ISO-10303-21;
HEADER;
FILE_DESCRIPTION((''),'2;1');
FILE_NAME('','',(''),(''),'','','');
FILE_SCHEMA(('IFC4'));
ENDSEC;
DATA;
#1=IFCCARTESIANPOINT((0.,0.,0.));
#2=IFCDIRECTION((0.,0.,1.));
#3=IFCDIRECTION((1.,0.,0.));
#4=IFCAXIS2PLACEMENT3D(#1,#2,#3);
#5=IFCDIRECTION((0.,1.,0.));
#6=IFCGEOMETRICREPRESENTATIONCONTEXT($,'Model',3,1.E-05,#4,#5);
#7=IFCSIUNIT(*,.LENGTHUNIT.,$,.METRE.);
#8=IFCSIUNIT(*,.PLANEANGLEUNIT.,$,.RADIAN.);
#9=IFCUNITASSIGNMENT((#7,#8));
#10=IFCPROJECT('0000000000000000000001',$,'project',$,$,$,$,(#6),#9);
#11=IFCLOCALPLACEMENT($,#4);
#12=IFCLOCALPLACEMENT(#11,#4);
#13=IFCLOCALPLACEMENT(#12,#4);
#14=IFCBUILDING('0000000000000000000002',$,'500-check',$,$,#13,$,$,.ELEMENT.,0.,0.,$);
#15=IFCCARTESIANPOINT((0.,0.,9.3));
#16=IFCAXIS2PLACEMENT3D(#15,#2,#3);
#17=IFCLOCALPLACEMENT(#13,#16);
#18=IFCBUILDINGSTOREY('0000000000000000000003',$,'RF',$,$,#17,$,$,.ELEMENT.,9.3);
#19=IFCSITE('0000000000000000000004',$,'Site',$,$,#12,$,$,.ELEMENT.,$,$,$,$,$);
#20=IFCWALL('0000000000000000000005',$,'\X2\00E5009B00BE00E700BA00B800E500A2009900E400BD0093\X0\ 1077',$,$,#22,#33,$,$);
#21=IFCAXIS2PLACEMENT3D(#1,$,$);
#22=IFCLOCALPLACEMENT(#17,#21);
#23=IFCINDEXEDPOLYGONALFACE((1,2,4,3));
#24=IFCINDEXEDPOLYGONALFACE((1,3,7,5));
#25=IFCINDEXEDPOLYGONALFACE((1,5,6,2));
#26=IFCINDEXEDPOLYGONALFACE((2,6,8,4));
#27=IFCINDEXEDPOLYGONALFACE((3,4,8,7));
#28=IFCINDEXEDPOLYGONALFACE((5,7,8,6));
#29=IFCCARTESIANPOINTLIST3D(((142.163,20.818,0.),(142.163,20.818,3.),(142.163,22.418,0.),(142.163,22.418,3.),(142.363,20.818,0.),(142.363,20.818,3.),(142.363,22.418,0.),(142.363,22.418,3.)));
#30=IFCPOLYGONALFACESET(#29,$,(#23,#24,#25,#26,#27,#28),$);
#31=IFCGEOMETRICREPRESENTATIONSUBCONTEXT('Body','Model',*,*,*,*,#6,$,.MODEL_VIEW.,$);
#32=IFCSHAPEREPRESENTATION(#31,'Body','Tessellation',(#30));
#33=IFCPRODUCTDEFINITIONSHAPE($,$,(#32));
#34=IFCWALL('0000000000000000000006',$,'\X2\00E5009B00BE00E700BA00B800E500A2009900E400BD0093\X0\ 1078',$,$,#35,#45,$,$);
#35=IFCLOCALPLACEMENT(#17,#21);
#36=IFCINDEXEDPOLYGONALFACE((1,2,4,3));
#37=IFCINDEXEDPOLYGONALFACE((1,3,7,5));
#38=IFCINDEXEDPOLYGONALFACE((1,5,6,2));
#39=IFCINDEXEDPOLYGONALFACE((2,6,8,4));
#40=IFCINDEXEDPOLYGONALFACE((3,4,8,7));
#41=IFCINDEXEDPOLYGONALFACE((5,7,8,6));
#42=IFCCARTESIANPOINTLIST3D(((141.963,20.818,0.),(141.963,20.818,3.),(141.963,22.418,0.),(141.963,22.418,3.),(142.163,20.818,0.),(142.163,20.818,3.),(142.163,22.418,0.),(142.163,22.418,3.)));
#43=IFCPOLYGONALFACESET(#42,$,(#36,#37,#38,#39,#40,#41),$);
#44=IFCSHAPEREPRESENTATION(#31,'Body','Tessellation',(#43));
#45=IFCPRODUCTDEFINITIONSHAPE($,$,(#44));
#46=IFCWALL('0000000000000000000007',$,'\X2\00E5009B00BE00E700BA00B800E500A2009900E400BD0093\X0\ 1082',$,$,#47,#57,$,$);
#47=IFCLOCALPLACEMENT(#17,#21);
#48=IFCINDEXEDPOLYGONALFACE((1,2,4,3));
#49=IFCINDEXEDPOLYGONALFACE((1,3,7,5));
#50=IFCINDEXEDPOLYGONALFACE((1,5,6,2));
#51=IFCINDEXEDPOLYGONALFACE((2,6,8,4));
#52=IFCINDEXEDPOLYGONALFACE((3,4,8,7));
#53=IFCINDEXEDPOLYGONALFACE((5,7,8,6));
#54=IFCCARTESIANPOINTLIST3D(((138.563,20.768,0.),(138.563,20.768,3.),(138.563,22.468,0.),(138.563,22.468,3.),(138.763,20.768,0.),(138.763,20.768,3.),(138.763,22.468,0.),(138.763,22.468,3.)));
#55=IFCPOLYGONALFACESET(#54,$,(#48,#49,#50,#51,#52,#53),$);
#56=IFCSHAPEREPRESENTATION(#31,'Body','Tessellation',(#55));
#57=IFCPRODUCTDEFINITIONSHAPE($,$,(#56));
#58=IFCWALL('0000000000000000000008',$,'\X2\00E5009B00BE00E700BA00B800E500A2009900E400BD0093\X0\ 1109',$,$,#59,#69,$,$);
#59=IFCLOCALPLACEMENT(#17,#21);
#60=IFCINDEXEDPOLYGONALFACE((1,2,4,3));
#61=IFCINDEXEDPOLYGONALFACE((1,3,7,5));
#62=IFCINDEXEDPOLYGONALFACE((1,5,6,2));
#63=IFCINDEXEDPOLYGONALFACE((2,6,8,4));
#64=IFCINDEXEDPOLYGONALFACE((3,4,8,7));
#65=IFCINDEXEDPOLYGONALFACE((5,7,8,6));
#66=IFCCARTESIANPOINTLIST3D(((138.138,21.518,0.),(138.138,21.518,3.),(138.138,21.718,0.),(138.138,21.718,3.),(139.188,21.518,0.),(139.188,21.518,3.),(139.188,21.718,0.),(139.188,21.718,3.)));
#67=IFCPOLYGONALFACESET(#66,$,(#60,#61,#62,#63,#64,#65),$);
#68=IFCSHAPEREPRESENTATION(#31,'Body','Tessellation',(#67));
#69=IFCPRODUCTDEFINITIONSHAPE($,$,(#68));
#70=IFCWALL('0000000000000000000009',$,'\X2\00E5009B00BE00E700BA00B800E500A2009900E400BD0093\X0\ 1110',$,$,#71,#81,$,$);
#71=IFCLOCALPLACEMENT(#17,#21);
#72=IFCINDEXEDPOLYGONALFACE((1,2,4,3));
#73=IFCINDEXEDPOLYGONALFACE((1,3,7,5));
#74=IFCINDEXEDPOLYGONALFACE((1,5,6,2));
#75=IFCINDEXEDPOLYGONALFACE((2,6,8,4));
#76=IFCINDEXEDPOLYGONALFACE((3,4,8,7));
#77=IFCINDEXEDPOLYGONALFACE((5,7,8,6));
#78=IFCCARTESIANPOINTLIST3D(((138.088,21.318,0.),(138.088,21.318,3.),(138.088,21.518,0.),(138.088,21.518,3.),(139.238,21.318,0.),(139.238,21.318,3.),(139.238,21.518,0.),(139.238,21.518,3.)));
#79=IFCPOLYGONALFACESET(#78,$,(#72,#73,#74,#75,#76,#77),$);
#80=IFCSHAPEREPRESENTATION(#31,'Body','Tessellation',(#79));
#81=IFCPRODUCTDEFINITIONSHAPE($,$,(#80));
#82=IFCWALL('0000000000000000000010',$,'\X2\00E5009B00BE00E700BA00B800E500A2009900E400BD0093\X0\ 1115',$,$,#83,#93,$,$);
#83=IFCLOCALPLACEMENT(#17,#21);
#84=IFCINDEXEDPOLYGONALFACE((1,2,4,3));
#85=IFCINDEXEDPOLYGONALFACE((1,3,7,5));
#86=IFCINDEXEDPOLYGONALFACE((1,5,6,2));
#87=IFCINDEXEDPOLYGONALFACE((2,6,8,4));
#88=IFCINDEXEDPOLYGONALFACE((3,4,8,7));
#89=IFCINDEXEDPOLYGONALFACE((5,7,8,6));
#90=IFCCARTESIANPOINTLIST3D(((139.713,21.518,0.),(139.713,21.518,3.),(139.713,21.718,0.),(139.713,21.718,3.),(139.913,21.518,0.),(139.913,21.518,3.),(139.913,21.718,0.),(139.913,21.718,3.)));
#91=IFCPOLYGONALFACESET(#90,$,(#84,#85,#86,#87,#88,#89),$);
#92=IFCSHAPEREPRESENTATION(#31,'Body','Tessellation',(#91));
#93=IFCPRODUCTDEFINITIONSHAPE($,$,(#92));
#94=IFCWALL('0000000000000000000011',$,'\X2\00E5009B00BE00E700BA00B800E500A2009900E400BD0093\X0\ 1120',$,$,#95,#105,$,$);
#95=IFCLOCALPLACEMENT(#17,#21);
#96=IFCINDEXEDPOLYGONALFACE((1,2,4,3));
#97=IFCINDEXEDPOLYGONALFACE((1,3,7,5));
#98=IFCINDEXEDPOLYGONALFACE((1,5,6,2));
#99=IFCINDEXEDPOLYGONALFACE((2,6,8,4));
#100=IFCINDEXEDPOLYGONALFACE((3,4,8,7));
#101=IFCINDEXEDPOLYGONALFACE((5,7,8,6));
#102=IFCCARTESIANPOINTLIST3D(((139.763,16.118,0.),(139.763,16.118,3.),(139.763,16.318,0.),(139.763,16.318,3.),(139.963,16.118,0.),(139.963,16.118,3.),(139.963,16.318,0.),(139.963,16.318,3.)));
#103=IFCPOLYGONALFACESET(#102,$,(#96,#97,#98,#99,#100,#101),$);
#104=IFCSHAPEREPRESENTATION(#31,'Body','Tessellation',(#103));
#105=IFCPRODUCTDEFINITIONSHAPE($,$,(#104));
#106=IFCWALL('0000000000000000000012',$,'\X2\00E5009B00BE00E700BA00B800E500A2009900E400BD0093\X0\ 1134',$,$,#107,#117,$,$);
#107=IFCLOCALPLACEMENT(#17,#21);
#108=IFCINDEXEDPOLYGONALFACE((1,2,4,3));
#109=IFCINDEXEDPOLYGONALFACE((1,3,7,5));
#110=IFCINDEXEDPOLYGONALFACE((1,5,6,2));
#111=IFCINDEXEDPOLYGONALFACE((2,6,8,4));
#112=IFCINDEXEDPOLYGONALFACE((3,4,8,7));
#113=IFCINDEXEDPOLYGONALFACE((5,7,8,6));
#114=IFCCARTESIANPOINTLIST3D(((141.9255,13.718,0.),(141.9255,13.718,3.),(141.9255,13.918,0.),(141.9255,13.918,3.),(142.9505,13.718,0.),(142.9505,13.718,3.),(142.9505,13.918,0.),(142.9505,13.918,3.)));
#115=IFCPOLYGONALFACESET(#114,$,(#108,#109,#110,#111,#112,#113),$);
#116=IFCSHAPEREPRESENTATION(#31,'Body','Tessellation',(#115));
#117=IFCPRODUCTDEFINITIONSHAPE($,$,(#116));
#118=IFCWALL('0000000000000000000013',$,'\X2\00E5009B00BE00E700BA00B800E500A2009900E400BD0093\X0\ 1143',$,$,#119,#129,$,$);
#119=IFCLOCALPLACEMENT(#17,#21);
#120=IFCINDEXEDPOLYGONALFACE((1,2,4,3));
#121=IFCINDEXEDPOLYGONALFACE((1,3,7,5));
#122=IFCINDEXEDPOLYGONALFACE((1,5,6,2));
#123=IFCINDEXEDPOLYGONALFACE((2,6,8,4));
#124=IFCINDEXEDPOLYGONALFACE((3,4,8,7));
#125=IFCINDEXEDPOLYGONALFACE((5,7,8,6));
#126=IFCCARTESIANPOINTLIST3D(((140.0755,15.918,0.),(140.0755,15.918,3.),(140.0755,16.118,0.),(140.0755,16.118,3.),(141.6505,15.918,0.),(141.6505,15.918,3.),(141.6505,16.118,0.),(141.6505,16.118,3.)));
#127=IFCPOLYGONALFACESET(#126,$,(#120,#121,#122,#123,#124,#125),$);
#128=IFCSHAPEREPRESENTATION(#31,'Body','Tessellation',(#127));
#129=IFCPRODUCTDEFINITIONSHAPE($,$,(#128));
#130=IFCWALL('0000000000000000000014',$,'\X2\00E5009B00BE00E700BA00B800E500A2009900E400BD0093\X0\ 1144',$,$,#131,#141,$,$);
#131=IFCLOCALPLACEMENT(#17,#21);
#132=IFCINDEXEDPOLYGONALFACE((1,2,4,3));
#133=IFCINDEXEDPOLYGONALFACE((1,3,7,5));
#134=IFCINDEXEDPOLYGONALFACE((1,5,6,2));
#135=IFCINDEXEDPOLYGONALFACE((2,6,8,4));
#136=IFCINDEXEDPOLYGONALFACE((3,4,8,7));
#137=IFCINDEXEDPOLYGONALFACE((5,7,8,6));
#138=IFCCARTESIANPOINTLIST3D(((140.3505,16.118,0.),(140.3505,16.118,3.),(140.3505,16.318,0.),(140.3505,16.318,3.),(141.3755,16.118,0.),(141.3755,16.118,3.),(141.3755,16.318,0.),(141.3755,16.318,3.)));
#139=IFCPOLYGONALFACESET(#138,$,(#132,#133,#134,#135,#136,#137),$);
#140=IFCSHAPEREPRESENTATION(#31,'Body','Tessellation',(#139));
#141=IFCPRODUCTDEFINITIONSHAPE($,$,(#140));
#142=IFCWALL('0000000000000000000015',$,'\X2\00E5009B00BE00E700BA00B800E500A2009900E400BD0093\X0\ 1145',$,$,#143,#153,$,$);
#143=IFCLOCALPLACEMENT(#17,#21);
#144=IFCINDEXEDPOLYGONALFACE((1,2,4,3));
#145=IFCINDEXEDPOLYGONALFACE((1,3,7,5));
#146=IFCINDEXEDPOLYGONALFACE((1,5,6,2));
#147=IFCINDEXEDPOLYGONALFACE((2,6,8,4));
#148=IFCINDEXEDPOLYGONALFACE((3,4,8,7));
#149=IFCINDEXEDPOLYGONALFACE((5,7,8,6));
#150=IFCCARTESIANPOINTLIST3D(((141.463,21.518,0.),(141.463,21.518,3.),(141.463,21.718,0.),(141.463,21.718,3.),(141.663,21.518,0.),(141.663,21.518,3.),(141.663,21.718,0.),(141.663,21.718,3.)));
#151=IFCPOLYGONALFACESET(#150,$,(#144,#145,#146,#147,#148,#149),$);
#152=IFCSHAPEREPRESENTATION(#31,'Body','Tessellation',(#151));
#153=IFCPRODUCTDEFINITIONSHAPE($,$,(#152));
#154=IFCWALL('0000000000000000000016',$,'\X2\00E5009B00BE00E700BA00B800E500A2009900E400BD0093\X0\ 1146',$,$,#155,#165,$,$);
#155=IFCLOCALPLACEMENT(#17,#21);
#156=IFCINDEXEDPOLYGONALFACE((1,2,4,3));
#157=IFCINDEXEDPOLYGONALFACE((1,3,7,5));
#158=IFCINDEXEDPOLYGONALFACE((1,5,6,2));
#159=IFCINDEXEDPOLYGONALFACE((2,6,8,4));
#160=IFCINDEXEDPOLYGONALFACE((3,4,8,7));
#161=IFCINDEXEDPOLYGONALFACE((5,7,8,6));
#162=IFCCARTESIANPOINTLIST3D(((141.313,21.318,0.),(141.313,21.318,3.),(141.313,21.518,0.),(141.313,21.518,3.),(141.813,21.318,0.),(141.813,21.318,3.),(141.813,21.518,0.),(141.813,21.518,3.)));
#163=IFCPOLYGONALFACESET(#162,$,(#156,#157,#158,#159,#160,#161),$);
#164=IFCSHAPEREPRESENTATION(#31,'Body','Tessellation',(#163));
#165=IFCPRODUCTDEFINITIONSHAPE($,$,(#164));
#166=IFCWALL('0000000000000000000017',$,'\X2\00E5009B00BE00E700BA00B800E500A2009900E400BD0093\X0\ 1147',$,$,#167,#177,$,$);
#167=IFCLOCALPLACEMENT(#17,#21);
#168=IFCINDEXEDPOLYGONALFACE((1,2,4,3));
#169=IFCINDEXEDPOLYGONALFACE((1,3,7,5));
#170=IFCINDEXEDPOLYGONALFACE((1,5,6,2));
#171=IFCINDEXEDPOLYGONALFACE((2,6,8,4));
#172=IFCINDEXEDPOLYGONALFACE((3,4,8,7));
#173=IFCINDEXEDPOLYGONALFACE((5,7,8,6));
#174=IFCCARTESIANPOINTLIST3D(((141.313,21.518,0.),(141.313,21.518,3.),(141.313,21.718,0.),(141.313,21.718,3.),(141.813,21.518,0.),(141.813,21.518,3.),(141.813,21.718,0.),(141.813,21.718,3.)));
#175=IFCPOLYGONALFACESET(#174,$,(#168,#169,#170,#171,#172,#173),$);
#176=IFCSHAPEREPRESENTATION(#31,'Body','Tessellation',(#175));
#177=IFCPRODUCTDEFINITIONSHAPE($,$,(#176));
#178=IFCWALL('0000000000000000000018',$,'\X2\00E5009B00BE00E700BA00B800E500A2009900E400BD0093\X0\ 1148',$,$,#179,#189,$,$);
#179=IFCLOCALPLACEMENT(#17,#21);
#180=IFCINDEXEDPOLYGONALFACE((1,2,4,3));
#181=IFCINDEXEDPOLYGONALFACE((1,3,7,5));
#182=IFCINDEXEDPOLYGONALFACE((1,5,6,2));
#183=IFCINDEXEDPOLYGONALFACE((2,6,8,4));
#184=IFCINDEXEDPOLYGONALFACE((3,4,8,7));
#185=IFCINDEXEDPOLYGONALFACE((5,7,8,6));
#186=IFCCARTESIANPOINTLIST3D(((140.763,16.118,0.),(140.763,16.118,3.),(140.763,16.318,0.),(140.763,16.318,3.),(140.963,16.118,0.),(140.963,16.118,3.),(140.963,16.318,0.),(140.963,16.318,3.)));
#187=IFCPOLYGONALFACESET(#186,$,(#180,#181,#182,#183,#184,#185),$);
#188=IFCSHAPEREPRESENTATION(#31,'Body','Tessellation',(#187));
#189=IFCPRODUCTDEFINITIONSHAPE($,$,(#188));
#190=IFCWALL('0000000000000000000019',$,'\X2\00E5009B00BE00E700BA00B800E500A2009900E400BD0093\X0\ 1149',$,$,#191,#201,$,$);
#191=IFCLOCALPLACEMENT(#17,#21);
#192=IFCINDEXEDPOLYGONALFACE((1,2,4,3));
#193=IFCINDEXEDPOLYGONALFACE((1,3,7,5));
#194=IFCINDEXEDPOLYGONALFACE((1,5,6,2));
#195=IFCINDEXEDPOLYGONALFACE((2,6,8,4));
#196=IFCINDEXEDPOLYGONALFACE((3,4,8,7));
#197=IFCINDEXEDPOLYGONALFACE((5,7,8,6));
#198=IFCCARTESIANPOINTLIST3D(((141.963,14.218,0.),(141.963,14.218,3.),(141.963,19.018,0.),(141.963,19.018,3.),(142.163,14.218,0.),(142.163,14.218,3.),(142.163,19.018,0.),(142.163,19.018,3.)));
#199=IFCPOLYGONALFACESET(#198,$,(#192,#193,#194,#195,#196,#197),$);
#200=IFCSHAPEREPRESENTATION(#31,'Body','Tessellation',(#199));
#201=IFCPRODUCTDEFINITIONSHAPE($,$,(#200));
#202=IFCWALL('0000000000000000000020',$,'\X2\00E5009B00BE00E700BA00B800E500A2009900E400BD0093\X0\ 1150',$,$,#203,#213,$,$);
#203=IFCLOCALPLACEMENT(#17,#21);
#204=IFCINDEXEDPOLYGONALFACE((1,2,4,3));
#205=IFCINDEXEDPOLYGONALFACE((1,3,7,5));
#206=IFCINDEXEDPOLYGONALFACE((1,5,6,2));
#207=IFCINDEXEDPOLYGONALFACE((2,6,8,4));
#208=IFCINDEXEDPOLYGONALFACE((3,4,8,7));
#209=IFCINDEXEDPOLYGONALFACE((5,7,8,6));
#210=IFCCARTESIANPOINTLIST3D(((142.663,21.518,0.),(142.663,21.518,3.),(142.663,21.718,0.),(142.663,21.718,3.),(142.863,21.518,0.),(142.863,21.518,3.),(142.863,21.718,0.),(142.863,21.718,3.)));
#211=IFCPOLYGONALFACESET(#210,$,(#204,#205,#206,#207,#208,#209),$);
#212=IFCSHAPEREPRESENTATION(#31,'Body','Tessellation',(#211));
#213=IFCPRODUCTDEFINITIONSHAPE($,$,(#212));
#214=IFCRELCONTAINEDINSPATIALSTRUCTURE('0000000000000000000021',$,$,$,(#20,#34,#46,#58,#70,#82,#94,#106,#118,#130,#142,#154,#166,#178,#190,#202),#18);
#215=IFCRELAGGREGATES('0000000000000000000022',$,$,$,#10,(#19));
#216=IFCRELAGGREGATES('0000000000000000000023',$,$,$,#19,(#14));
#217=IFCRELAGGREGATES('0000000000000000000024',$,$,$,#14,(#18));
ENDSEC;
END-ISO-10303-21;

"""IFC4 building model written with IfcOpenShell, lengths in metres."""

from ifc_helpers import new_model, si_unit, direction, frame, frame_2d, origin_with_axes, place, context, subcontext, project, spatial, rectangle, extrude, element, save


model = new_model("IFC4")

# Units and contexts
model_context = context("Model", 3, precision=1e-05, world=origin_with_axes(), true_north=direction((0.0, 1.0, 0.0)))
body_context = subcontext(model_context, "Body", "Model", "MODEL_VIEW")
ifc_project = project(units=[si_unit("LENGTHUNIT", "METRE"), si_unit("PLANEANGLEUNIT", "RADIAN")], contexts=[model_context])

# Site, building, storey
placement = place(None, origin_with_axes())
site_placement = place(placement, origin_with_axes())
site = spatial("IfcSite", under=ifc_project, at=site_placement, Name="Site", CompositionType="ELEMENT")
building_placement = place(site_placement, origin_with_axes())
building = spatial("IfcBuilding", under=site, at=building_placement, Name="500-check", CompositionType="ELEMENT", ElevationOfRefHeight=0.0, ElevationOfTerrain=0.0)
storey_placement = place(building_placement, frame((0.0, 0.0, 9.3), z_axis=(0.0, 0.0, 1.0), x_axis=(1.0, 0.0, 0.0)))
storey = spatial("IfcBuildingStorey", under=building, at=storey_placement, Name="RF", CompositionType="ELEMENT", Elevation=9.3)

# Walls
for number, where, z_axis, x_axis, name in (
    (1, (142.263, 21.618, 0.0), (0.0, 0.0, 1.0), (0.0, 1.0, 0.0), "å\u009b¾çº¸å¢\u0099ä½\u0093 1077"),
    (2, (142.063, 21.618, 0.0), (0.0, 0.0, 1.0), (0.0, 1.0, 0.0), "å\u009b¾çº¸å¢\u0099ä½\u0093 1078"),
):
    element("IfcWall", number, at=place(storey_placement, frame(where, z_axis=z_axis, x_axis=x_axis)), inside=storey, Name=name, context=body_context, shape_type="SweptSolid", body=[
        extrude(rectangle(XDim=1.6, YDim=0.2, at=frame_2d((0.0, 0.0), x_axis=(1.0, 0.0, 0.0))), frame((0.0, 0.0, 0.0), z_axis=(0.0, 0.0, 1.0)), (0.0, 0.0, 1.0), 3.0),
    ])
wall_1_placement = place(storey_placement, frame((138.663, 21.618, 0.0), z_axis=(0.0, 0.0, 1.0), x_axis=(0.0, 1.0, 0.0)))
element("IfcWall", 3, at=wall_1_placement, inside=storey, Name="å\u009b¾çº¸å¢\u0099ä½\u0093 1082", context=body_context, shape_type="SweptSolid", body=[
    extrude(rectangle(XDim=1.7, YDim=0.2, at=frame_2d((0.0, 0.0), x_axis=(1.0, 0.0, 0.0))), frame((0.0, 0.0, 0.0), z_axis=(0.0, 0.0, 1.0)), (0.0, 0.0, 1.0), 3.0),
])
wall_2_placement = place(storey_placement, frame((138.663, 21.618, 0.0), z_axis=(0.0, 0.0, 1.0), x_axis=(1.0, 0.0, 0.0)))
element("IfcWall", 4, at=wall_2_placement, inside=storey, Name="å\u009b¾çº¸å¢\u0099ä½\u0093 1109", context=body_context, shape_type="SweptSolid", body=[
    extrude(rectangle(XDim=1.05, YDim=0.2, at=frame_2d((0.0, 0.0), x_axis=(1.0, 0.0, 0.0))), frame((0.0, 0.0, 0.0), z_axis=(0.0, 0.0, 1.0)), (0.0, 0.0, 1.0), 3.0),
])
wall_3_placement = place(storey_placement, frame((138.663, 21.418, 0.0), z_axis=(0.0, 0.0, 1.0), x_axis=(1.0, 0.0, 0.0)))
element("IfcWall", 5, at=wall_3_placement, inside=storey, Name="å\u009b¾çº¸å¢\u0099ä½\u0093 1110", context=body_context, shape_type="SweptSolid", body=[
    extrude(rectangle(XDim=1.15, YDim=0.2, at=frame_2d((0.0, 0.0), x_axis=(1.0, 0.0, 0.0))), frame((0.0, 0.0, 0.0), z_axis=(0.0, 0.0, 1.0)), (0.0, 0.0, 1.0), 3.0),
])
for number, where, z_axis, x_axis, name in (
    (6, (139.813, 21.618, 0.0), (0.0, 0.0, 1.0), (0.0, -1.0, 0.0), "å\u009b¾çº¸å¢\u0099ä½\u0093 1115"),
    (7, (139.863, 16.218, 0.0), (0.0, 0.0, 1.0), (0.0, -1.0, 0.0), "å\u009b¾çº¸å¢\u0099ä½\u0093 1120"),
):
    element("IfcWall", number, at=place(storey_placement, frame(where, z_axis=z_axis, x_axis=x_axis)), inside=storey, Name=name, context=body_context, shape_type="SweptSolid", body=[
        extrude(rectangle(XDim=0.2, YDim=0.2, at=frame_2d((0.0, 0.0), x_axis=(1.0, 0.0, 0.0))), frame((0.0, 0.0, 0.0), z_axis=(0.0, 0.0, 1.0)), (0.0, 0.0, 1.0), 3.0),
    ])
wall_4_placement = place(storey_placement, frame((142.438, 13.818, 0.0), z_axis=(0.0, 0.0, 1.0), x_axis=(1.0, 0.0, 0.0)))
element("IfcWall", 8, at=wall_4_placement, inside=storey, Name="å\u009b¾çº¸å¢\u0099ä½\u0093 1134", context=body_context, shape_type="SweptSolid", body=[
    extrude(rectangle(XDim=1.025, YDim=0.2, at=frame_2d((0.0, 0.0), x_axis=(1.0, 0.0, 0.0))), frame((0.0, 0.0, 0.0), z_axis=(0.0, 0.0, 1.0)), (0.0, 0.0, 1.0), 3.0),
])
wall_5_placement = place(storey_placement, frame((140.863, 16.018, 0.0), z_axis=(0.0, 0.0, 1.0), x_axis=(1.0, 0.0, 0.0)))
element("IfcWall", 9, at=wall_5_placement, inside=storey, Name="å\u009b¾çº¸å¢\u0099ä½\u0093 1143", context=body_context, shape_type="SweptSolid", body=[
    extrude(rectangle(XDim=1.575, YDim=0.2, at=frame_2d((0.0, 0.0), x_axis=(1.0, 0.0, 0.0))), frame((0.0, 0.0, 0.0), z_axis=(0.0, 0.0, 1.0)), (0.0, 0.0, 1.0), 3.0),
])
wall_6_placement = place(storey_placement, frame((140.863, 16.218, 0.0), z_axis=(0.0, 0.0, 1.0), x_axis=(1.0, 0.0, 0.0)))
element("IfcWall", 10, at=wall_6_placement, inside=storey, Name="å\u009b¾çº¸å¢\u0099ä½\u0093 1144", context=body_context, shape_type="SweptSolid", body=[
    extrude(rectangle(XDim=1.025, YDim=0.2, at=frame_2d((0.0, 0.0), x_axis=(1.0, 0.0, 0.0))), frame((0.0, 0.0, 0.0), z_axis=(0.0, 0.0, 1.0)), (0.0, 0.0, 1.0), 3.0),
])
wall_7_placement = place(storey_placement, frame((141.563, 21.618, 0.0), z_axis=(0.0, 0.0, 1.0), x_axis=(0.0, -1.0, 0.0)))
element("IfcWall", 11, at=wall_7_placement, inside=storey, Name="å\u009b¾çº¸å¢\u0099ä½\u0093 1145", context=body_context, shape_type="SweptSolid", body=[
    extrude(rectangle(XDim=0.2, YDim=0.2, at=frame_2d((0.0, 0.0), x_axis=(1.0, 0.0, 0.0))), frame((0.0, 0.0, 0.0), z_axis=(0.0, 0.0, 1.0)), (0.0, 0.0, 1.0), 3.0),
])
for number, where, z_axis, x_axis, name in (
    (12, (141.563, 21.418, 0.0), (0.0, 0.0, 1.0), (1.0, 0.0, 0.0), "å\u009b¾çº¸å¢\u0099ä½\u0093 1146"),
    (13, (141.563, 21.618, 0.0), (0.0, 0.0, 1.0), (1.0, 0.0, 0.0), "å\u009b¾çº¸å¢\u0099ä½\u0093 1147"),
):
    element("IfcWall", number, at=place(storey_placement, frame(where, z_axis=z_axis, x_axis=x_axis)), inside=storey, Name=name, context=body_context, shape_type="SweptSolid", body=[
        extrude(rectangle(XDim=0.5, YDim=0.2, at=frame_2d((0.0, 0.0), x_axis=(1.0, 0.0, 0.0))), frame((0.0, 0.0, 0.0), z_axis=(0.0, 0.0, 1.0)), (0.0, 0.0, 1.0), 3.0),
    ])
wall_8_placement = place(storey_placement, frame((140.863, 16.218, 0.0), z_axis=(0.0, 0.0, 1.0), x_axis=(0.0, -1.0, 0.0)))
element("IfcWall", 14, at=wall_8_placement, inside=storey, Name="å\u009b¾çº¸å¢\u0099ä½\u0093 1148", context=body_context, shape_type="SweptSolid", body=[
    extrude(rectangle(XDim=0.2, YDim=0.2, at=frame_2d((0.0, 0.0), x_axis=(1.0, 0.0, 0.0))), frame((0.0, 0.0, 0.0), z_axis=(0.0, 0.0, 1.0)), (0.0, 0.0, 1.0), 3.0),
])
wall_9_placement = place(storey_placement, frame((142.063, 16.618, 0.0), z_axis=(0.0, 0.0, 1.0), x_axis=(0.0, 1.0, 0.0)))
element("IfcWall", 15, at=wall_9_placement, inside=storey, Name="å\u009b¾çº¸å¢\u0099ä½\u0093 1149", context=body_context, shape_type="SweptSolid", body=[
    extrude(rectangle(XDim=4.8, YDim=0.2, at=frame_2d((0.0, 0.0), x_axis=(1.0, 0.0, 0.0))), frame((0.0, 0.0, 0.0), z_axis=(0.0, 0.0, 1.0)), (0.0, 0.0, 1.0), 3.0),
])
wall_10_placement = place(storey_placement, frame((142.763, 21.618, 0.0), z_axis=(0.0, 0.0, 1.0), x_axis=(0.0, -1.0, 0.0)))
element("IfcWall", 16, at=wall_10_placement, inside=storey, Name="å\u009b¾çº¸å¢\u0099ä½\u0093 1150", context=body_context, shape_type="SweptSolid", body=[
    extrude(rectangle(XDim=0.2, YDim=0.2, at=frame_2d((0.0, 0.0), x_axis=(1.0, 0.0, 0.0))), frame((0.0, 0.0, 0.0), z_axis=(0.0, 0.0, 1.0)), (0.0, 0.0, 1.0), 3.0),
])

save(model, "model.ifc")
